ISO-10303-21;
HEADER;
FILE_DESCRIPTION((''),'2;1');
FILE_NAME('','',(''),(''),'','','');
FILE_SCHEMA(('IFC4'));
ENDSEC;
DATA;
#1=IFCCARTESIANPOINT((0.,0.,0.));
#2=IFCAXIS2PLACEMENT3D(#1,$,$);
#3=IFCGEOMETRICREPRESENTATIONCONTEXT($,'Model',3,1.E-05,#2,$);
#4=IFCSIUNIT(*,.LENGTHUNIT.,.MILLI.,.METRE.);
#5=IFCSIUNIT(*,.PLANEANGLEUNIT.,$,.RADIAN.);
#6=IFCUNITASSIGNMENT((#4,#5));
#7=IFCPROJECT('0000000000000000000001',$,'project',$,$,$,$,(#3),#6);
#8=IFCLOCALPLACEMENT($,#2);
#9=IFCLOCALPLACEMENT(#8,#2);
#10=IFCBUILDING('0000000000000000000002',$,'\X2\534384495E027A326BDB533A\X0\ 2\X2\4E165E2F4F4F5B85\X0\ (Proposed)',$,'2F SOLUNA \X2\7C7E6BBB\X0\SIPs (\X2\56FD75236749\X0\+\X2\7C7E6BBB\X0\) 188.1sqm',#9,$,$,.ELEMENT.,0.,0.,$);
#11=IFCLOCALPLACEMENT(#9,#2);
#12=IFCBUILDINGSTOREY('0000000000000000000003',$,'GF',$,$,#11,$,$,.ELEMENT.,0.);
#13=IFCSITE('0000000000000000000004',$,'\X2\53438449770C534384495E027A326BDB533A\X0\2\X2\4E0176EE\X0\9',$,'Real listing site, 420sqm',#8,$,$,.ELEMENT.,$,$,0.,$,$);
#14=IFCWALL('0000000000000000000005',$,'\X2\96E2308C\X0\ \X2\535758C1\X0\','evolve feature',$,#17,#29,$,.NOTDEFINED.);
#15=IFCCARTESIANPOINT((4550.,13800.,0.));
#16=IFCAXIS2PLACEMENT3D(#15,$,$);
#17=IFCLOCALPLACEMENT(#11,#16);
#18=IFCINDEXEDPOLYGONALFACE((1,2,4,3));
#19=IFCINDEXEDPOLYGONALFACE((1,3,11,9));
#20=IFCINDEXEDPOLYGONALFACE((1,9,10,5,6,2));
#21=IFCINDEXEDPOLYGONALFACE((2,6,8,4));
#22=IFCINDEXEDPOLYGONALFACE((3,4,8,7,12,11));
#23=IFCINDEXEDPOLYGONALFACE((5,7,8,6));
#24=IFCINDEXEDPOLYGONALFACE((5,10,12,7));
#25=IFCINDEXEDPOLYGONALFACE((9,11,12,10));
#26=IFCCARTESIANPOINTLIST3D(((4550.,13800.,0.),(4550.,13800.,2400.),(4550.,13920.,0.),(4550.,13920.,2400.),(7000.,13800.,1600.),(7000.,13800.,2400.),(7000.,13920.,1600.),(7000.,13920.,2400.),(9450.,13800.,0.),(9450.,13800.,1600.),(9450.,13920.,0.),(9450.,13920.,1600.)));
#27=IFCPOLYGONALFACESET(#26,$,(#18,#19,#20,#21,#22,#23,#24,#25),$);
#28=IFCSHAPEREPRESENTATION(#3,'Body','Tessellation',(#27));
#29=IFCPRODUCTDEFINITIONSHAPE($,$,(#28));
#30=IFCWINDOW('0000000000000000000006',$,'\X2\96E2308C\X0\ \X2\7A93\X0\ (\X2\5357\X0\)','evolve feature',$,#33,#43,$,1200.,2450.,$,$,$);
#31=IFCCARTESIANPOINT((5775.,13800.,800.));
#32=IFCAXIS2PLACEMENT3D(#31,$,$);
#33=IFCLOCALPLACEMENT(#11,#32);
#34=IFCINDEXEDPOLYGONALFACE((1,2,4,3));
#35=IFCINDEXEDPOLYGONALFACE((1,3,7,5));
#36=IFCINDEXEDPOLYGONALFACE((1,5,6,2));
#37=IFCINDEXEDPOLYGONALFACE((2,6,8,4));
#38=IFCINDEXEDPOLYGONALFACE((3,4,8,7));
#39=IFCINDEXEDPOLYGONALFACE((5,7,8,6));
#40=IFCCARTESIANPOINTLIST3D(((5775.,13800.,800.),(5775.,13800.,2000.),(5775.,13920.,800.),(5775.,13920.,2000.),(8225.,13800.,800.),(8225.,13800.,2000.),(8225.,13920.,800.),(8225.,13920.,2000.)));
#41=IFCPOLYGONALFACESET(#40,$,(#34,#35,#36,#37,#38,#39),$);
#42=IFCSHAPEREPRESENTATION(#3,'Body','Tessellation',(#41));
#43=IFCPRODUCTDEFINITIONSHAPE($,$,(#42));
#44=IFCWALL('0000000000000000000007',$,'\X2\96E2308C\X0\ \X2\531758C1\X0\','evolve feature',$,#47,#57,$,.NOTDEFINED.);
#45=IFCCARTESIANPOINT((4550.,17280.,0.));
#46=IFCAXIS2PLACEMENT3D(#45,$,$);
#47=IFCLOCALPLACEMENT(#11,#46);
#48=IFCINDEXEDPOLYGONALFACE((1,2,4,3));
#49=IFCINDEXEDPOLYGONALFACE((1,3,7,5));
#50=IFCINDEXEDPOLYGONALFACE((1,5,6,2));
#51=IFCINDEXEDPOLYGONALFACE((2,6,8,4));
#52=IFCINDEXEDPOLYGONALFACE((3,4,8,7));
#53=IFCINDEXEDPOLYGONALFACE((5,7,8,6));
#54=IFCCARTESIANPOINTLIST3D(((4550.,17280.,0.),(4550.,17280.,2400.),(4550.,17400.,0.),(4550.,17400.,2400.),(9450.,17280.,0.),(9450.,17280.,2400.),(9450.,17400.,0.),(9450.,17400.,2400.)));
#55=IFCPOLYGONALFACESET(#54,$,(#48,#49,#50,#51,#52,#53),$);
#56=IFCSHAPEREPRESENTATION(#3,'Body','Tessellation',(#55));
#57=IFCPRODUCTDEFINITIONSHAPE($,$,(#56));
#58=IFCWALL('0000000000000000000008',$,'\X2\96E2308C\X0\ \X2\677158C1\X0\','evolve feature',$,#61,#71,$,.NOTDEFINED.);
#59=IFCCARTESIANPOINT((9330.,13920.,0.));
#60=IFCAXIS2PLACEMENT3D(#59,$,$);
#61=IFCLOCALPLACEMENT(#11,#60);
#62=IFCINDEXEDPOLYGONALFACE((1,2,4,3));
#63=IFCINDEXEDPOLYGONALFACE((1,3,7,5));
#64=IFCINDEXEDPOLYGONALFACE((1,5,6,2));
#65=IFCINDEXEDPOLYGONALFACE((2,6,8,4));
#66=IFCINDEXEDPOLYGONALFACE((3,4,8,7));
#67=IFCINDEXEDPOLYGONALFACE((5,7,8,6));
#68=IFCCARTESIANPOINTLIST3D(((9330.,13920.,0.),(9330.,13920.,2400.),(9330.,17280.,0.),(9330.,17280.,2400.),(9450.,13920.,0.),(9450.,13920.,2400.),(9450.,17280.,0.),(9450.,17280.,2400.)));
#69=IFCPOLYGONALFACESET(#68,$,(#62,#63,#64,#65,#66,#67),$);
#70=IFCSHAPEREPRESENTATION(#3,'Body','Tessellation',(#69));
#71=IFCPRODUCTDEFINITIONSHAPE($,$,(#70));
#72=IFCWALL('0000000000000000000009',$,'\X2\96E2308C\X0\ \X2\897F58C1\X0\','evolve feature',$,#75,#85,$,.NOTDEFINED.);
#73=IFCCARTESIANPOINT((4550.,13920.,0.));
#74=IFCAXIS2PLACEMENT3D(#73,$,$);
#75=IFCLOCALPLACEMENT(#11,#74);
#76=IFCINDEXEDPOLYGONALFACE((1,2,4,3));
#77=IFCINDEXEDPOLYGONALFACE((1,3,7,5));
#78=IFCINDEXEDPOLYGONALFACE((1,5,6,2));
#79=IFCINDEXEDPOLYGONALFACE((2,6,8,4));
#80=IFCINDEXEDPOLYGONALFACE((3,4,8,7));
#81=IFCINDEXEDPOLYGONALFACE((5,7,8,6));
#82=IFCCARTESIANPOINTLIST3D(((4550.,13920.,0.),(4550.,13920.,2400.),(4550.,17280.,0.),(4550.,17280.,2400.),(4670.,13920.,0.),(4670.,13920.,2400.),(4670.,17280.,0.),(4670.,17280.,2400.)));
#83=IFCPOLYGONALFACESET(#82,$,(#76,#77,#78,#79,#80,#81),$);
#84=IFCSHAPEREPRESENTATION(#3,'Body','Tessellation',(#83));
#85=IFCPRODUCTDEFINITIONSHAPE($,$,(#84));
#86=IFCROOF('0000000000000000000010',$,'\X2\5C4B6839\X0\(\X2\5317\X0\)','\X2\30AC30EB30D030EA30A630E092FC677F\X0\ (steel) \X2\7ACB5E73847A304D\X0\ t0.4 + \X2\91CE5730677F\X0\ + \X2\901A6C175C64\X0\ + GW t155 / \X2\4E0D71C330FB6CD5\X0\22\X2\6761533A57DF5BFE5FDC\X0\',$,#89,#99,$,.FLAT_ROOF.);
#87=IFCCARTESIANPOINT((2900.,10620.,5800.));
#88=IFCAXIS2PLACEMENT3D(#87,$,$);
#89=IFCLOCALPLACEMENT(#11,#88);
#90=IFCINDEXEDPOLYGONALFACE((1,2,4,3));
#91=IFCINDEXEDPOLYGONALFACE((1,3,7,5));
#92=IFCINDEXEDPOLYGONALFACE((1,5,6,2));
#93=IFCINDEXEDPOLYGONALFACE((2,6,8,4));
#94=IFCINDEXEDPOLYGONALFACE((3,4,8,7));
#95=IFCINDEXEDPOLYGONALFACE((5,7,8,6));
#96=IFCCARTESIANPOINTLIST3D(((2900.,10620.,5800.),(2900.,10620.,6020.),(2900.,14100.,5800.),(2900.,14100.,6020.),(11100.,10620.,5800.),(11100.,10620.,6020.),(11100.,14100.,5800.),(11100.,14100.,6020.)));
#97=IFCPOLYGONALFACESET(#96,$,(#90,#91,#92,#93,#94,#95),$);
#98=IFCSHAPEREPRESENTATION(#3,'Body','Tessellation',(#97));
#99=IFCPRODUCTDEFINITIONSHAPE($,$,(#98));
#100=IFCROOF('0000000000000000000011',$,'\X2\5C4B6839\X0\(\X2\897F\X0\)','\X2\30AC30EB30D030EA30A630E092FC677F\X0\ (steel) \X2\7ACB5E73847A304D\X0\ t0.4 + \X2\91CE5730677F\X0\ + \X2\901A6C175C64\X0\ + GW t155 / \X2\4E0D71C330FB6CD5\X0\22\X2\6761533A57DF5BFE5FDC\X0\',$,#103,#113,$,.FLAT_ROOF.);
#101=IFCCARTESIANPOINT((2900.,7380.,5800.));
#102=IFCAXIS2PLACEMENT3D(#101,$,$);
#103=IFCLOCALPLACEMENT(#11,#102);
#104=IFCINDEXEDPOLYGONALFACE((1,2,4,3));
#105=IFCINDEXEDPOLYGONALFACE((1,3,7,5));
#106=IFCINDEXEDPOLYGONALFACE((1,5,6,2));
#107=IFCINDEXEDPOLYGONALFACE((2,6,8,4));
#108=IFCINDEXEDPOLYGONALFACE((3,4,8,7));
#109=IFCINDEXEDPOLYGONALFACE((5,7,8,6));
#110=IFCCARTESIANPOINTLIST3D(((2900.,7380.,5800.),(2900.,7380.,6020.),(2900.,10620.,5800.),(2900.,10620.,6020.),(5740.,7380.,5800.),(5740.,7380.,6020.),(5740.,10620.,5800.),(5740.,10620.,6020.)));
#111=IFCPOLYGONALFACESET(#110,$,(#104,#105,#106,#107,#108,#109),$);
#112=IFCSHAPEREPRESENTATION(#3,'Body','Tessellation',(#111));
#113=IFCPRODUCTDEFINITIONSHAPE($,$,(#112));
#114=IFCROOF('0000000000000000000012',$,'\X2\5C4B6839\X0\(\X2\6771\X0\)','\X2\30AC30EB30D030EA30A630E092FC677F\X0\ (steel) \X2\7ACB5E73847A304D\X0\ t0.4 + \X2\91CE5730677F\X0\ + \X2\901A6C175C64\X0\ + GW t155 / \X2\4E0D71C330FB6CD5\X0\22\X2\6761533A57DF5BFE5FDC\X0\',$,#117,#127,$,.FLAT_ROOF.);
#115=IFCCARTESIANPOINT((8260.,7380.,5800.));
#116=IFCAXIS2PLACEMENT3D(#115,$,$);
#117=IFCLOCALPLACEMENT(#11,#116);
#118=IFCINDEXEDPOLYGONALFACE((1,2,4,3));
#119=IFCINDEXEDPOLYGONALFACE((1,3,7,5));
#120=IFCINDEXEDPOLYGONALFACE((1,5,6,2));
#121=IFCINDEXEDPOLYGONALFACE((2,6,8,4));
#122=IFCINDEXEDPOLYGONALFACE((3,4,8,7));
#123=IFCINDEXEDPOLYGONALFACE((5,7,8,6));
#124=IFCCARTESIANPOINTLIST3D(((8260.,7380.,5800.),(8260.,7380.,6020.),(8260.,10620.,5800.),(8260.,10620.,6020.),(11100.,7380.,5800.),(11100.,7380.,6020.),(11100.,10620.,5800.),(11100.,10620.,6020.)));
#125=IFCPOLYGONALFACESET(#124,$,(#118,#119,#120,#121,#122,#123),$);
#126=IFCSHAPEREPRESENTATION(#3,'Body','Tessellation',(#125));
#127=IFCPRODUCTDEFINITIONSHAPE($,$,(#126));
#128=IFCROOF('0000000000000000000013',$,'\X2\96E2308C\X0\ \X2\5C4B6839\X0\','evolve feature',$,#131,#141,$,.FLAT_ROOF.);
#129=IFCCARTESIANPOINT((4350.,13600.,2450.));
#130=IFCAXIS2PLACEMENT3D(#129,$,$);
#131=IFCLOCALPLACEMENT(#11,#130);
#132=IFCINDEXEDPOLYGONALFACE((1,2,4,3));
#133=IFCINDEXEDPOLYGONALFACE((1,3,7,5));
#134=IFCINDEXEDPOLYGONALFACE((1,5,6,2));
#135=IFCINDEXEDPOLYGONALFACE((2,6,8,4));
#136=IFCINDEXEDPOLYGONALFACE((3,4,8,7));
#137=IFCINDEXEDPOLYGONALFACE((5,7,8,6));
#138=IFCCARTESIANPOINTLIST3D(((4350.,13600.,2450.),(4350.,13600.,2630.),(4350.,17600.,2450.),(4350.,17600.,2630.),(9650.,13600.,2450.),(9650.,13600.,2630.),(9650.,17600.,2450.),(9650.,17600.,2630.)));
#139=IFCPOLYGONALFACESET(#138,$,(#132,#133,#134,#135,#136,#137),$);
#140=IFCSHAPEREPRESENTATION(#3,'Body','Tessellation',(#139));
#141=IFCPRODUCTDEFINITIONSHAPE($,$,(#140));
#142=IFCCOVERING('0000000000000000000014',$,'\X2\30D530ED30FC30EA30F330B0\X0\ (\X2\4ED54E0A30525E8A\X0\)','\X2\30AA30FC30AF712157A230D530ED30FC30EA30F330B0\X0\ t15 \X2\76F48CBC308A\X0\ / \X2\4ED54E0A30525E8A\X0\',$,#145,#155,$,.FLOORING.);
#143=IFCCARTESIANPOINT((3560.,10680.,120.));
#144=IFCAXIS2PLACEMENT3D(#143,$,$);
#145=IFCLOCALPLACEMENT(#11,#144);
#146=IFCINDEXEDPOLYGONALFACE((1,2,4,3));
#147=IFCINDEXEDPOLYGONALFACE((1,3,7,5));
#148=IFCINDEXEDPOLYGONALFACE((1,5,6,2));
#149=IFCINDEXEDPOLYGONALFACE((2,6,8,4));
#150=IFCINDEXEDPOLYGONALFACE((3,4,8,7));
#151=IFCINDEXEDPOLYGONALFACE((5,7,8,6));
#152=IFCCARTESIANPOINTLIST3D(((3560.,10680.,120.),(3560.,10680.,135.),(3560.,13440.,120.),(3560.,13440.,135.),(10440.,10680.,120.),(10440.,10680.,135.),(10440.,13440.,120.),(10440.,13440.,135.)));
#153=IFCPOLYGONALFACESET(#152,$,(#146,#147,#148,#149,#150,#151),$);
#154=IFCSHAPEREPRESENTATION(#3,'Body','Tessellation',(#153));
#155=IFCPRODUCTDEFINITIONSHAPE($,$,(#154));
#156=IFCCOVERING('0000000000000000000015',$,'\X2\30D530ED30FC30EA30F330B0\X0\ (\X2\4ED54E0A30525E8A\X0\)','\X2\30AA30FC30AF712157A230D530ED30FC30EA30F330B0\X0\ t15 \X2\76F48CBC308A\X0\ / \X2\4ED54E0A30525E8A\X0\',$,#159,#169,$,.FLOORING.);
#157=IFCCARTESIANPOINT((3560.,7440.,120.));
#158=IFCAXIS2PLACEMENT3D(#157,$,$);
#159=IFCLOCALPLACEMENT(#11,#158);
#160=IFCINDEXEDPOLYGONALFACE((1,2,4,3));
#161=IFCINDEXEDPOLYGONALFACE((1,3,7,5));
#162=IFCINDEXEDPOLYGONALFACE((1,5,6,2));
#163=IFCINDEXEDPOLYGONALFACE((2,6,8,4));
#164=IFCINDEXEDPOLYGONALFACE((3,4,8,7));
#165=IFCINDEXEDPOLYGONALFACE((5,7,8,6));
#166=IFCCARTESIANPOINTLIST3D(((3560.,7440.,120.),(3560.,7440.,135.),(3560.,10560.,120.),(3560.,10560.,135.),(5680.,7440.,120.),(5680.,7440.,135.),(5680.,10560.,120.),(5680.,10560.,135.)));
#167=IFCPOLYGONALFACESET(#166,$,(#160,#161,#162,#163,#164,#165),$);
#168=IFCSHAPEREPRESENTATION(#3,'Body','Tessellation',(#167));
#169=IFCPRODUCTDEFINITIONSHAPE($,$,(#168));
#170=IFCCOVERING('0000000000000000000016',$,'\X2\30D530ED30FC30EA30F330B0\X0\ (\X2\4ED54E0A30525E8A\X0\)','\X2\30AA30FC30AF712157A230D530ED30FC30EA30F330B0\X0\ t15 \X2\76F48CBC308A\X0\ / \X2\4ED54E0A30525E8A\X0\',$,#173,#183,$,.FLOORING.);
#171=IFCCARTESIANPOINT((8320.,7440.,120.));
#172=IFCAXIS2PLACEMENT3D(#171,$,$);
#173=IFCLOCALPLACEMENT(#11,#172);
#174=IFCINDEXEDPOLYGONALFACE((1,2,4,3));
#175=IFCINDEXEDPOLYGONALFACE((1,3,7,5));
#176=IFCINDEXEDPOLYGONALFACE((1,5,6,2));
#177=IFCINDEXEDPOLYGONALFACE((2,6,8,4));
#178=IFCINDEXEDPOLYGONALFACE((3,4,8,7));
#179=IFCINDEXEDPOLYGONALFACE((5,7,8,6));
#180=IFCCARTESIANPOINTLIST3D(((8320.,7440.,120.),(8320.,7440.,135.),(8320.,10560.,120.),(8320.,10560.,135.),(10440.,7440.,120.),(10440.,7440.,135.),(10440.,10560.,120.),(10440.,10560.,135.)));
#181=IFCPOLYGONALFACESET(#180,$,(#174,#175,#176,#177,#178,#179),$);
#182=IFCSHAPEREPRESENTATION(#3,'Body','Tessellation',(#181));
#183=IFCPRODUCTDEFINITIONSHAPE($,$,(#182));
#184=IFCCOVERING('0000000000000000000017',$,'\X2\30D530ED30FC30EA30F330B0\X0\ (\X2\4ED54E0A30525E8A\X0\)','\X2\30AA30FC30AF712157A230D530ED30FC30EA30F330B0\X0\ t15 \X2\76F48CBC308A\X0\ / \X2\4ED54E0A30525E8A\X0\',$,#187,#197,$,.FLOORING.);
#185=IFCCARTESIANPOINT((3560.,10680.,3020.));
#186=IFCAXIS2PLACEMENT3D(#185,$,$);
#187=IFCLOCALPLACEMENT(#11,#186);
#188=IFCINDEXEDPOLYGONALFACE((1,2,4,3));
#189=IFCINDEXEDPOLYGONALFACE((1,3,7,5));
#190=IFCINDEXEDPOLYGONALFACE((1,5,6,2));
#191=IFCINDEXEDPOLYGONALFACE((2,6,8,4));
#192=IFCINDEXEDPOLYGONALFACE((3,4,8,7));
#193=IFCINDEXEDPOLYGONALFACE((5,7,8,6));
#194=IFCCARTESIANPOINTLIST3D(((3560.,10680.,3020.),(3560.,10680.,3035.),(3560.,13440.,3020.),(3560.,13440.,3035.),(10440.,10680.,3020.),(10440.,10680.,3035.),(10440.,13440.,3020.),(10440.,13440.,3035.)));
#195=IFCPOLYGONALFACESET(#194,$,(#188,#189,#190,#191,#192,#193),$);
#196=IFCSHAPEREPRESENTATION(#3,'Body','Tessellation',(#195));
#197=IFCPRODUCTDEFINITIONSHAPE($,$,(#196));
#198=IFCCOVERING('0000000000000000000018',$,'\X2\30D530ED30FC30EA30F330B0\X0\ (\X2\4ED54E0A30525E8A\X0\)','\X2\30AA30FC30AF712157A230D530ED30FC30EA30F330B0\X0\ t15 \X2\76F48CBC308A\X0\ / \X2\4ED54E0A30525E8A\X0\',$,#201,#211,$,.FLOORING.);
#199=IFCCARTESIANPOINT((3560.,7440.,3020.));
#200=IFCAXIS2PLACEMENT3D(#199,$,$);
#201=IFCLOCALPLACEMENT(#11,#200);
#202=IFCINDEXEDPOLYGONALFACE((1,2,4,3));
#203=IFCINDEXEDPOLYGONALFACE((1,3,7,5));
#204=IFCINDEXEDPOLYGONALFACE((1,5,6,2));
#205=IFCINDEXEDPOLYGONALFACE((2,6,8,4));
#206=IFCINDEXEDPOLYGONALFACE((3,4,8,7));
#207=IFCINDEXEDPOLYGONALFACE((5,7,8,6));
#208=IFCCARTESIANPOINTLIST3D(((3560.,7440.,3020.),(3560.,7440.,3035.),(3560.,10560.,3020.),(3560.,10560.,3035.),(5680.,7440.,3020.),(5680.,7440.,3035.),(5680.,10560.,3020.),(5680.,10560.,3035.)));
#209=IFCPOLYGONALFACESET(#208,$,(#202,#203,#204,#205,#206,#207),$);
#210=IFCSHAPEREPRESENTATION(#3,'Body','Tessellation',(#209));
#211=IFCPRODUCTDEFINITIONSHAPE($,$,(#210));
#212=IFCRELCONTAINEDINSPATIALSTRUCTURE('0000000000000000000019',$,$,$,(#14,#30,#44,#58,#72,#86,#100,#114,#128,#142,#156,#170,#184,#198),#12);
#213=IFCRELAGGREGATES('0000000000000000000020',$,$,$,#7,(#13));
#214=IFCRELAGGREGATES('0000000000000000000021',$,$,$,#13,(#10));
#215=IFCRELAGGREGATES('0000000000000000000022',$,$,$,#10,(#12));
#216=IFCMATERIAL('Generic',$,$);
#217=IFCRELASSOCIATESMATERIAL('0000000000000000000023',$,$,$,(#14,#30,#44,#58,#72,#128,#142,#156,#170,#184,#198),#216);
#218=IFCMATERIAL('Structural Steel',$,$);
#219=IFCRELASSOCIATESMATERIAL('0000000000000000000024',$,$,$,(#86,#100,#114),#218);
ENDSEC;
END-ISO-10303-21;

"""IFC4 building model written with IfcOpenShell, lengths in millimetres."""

from ifc_helpers import new_model, si_unit, frame, frame_2d, origin, place, context, project, spatial, rectangle, extrude, material, element, fill, save


model = new_model("IFC4")

# Units and contexts
model_context = context("Model", 3, precision=1e-05, world=origin())
ifc_project = project(units=[si_unit("LENGTHUNIT", "METRE", prefix="MILLI"), si_unit("PLANEANGLEUNIT", "RADIAN")], contexts=[model_context])

# Site, building, storey
site_placement = place(None, origin())
site = spatial("IfcSite", under=ifc_project, at=site_placement, Name="千葉県千葉市稲毛区2丁目9", ObjectType="Real listing site, 420sqm", CompositionType="ELEMENT", RefElevation=0.0)
building_placement = place(site_placement, origin())
building = spatial("IfcBuilding", under=site, at=building_placement, Name="千葉市稲毛区 2世帯住宅 (Proposed)", ObjectType="2F SOLUNA 籾殻SIPs (国産杉+籾殻) 188.1sqm", CompositionType="ELEMENT", ElevationOfRefHeight=0.0, ElevationOfTerrain=0.0)
storey_placement = place(building_placement, origin())
storey = spatial("IfcBuildingStorey", under=building, at=storey_placement, Name="GF", CompositionType="ELEMENT", Elevation=0.0)

# Shared definitions
ifc_material_1 = material(Name="Generic")

# Wall, opening, window
wall_1_placement = place(storey_placement, frame((4550.0, 13800.0, 0.0)))
wall_1 = element("IfcWall", 1, at=wall_1_placement, inside=storey, material=ifc_material_1, Name="離れ 南壁", Description="evolve feature", PredefinedType="NOTDEFINED", context=model_context, shape_type="SweptSolid", body=[
    extrude(rectangle(XDim=4900.0, YDim=120.0, at=frame_2d((2450.0, 60.0))), frame((4550.0, 13800.0, 0.0)), (0.0, 0.0, 1.0), 2400.0),
])
opening_1_placement = place(storey_placement, frame((5775.0, 13800.0, 800.0)))
opening_1 = element("IfcOpeningElement", 2, at=opening_1_placement, cuts=wall_1, PredefinedType="NOTDEFINED", context=model_context, shape_type="SweptSolid", body=[
    extrude(rectangle(XDim=2450.0, YDim=120.0, at=frame_2d((1225.0, 60.0))), frame((5775.0, 13800.0, 800.0)), (0.0, 0.0, 1.0), 1200.0),
])
window_1_placement = place(storey_placement, frame((5775.0, 13800.0, 800.0)))
window_1 = element("IfcWindow", 3, at=window_1_placement, inside=storey, material=ifc_material_1, Name="離れ 窓 (南)", Description="evolve feature", OverallHeight=1200.0, OverallWidth=2450.0, context=model_context, shape_type="SweptSolid", body=[
    extrude(rectangle(XDim=2450.0, YDim=120.0, at=frame_2d((1225.0, 60.0))), frame((5775.0, 13800.0, 800.0)), (0.0, 0.0, 1.0), 1200.0),
])
fill(opening_1, window_1)

# Walls
wall_2_placement = place(storey_placement, frame((4550.0, 17280.0, 0.0)))
element("IfcWall", 4, at=wall_2_placement, inside=storey, material=ifc_material_1, Name="離れ 北壁", Description="evolve feature", PredefinedType="NOTDEFINED", context=model_context, shape_type="SweptSolid", body=[
    extrude(rectangle(XDim=4900.0, YDim=120.0, at=frame_2d((2450.0, 60.0))), frame((4550.0, 17280.0, 0.0)), (0.0, 0.0, 1.0), 2400.0),
])
wall_3_placement = place(storey_placement, frame((9330.0, 13920.0, 0.0)))
element("IfcWall", 5, at=wall_3_placement, inside=storey, material=ifc_material_1, Name="離れ 東壁", Description="evolve feature", PredefinedType="NOTDEFINED", context=model_context, shape_type="SweptSolid", body=[
    extrude(rectangle(XDim=120.0, YDim=3360.0, at=frame_2d((60.0, 1680.0))), frame((9330.0, 13920.0, 0.0)), (0.0, 0.0, 1.0), 2400.0),
])
wall_4_placement = place(storey_placement, frame((4550.0, 13920.0, 0.0)))
element("IfcWall", 6, at=wall_4_placement, inside=storey, material=ifc_material_1, Name="離れ 西壁", Description="evolve feature", PredefinedType="NOTDEFINED", context=model_context, shape_type="SweptSolid", body=[
    extrude(rectangle(XDim=120.0, YDim=3360.0, at=frame_2d((60.0, 1680.0))), frame((4550.0, 13920.0, 0.0)), (0.0, 0.0, 1.0), 2400.0),
])

# Roofs
ifc_material_2 = material(Name="Structural Steel")
for number, where, name in (
    (7, (2900.0, 10620.0, 5800.0), "屋根(北)"),
):
    element("IfcRoof", number, at=place(storey_placement, frame(where)), inside=storey, material=ifc_material_2, Name=name, Description="ガルバリウム鋼板 (steel) 立平葺き t0.4 + 野地板 + 通気層 + GW t155 / 不燃・法22条区域対応", PredefinedType="FLAT_ROOF", context=model_context, shape_type="SweptSolid", body=[
        extrude(rectangle(XDim=8200.0, YDim=3480.0, at=frame_2d((4100.0, 1740.0))), frame((2900.0, 10620.0, 5800.0)), (0.0, 0.0, 1.0), 220.0),
    ])
roof_1_placement = place(storey_placement, frame((2900.0, 7380.0, 5800.0)))
element("IfcRoof", 8, at=roof_1_placement, inside=storey, material=ifc_material_2, Name="屋根(西)", Description="ガルバリウム鋼板 (steel) 立平葺き t0.4 + 野地板 + 通気層 + GW t155 / 不燃・法22条区域対応", PredefinedType="FLAT_ROOF", context=model_context, shape_type="SweptSolid", body=[
    extrude(rectangle(XDim=2840.0, YDim=3240.0, at=frame_2d((1420.0, 1620.0))), frame((2900.0, 7380.0, 5800.0)), (0.0, 0.0, 1.0), 220.0),
])
roof_2_placement = place(storey_placement, frame((8260.0, 7380.0, 5800.0)))
element("IfcRoof", 9, at=roof_2_placement, inside=storey, material=ifc_material_2, Name="屋根(東)", Description="ガルバリウム鋼板 (steel) 立平葺き t0.4 + 野地板 + 通気層 + GW t155 / 不燃・法22条区域対応", PredefinedType="FLAT_ROOF", context=model_context, shape_type="SweptSolid", body=[
    extrude(rectangle(XDim=2840.0, YDim=3240.0, at=frame_2d((1420.0, 1620.0))), frame((8260.0, 7380.0, 5800.0)), (0.0, 0.0, 1.0), 220.0),
])
roof_3_placement = place(storey_placement, frame((4350.0, 13600.0, 2450.0)))
element("IfcRoof", 10, at=roof_3_placement, inside=storey, material=ifc_material_1, Name="離れ 屋根", Description="evolve feature", PredefinedType="FLAT_ROOF", context=model_context, shape_type="SweptSolid", body=[
    extrude(rectangle(XDim=5300.0, YDim=4000.0, at=frame_2d((2650.0, 2000.0))), frame((4350.0, 13600.0, 2450.0)), (0.0, 0.0, 1.0), 180.0),
])

# Coverings
covering_1_placement = place(storey_placement, frame((3560.0, 10680.0, 120.0)))
element("IfcCovering", 11, at=covering_1_placement, inside=storey, material=ifc_material_1, Name="フローリング (仕上げ床)", Description="オーク無垢フローリング t15 直貼り / 仕上げ床", PredefinedType="FLOORING", context=model_context, shape_type="SweptSolid", body=[
    extrude(rectangle(XDim=6880.0, YDim=2760.0, at=frame_2d((3440.0, 1380.0))), frame((3560.0, 10680.0, 120.0)), (0.0, 0.0, 1.0), 15.0),
])
covering_2_placement = place(storey_placement, frame((3560.0, 7440.0, 120.0)))
element("IfcCovering", 12, at=covering_2_placement, inside=storey, material=ifc_material_1, Name="フローリング (仕上げ床)", Description="オーク無垢フローリング t15 直貼り / 仕上げ床", PredefinedType="FLOORING", context=model_context, shape_type="SweptSolid", body=[
    extrude(rectangle(XDim=2120.0, YDim=3120.0, at=frame_2d((1060.0, 1560.0))), frame((3560.0, 7440.0, 120.0)), (0.0, 0.0, 1.0), 15.0),
])
covering_3_placement = place(storey_placement, frame((8320.0, 7440.0, 120.0)))
element("IfcCovering", 13, at=covering_3_placement, inside=storey, material=ifc_material_1, Name="フローリング (仕上げ床)", Description="オーク無垢フローリング t15 直貼り / 仕上げ床", PredefinedType="FLOORING", context=model_context, shape_type="SweptSolid", body=[
    extrude(rectangle(XDim=2120.0, YDim=3120.0, at=frame_2d((1060.0, 1560.0))), frame((8320.0, 7440.0, 120.0)), (0.0, 0.0, 1.0), 15.0),
])
covering_4_placement = place(storey_placement, frame((3560.0, 10680.0, 3020.0)))
element("IfcCovering", 14, at=covering_4_placement, inside=storey, material=ifc_material_1, Name="フローリング (仕上げ床)", Description="オーク無垢フローリング t15 直貼り / 仕上げ床", PredefinedType="FLOORING", context=model_context, shape_type="SweptSolid", body=[
    extrude(rectangle(XDim=6880.0, YDim=2760.0, at=frame_2d((3440.0, 1380.0))), frame((3560.0, 10680.0, 3020.0)), (0.0, 0.0, 1.0), 15.0),
])
covering_5_placement = place(storey_placement, frame((3560.0, 7440.0, 3020.0)))
element("IfcCovering", 15, at=covering_5_placement, inside=storey, material=ifc_material_1, Name="フローリング (仕上げ床)", Description="オーク無垢フローリング t15 直貼り / 仕上げ床", PredefinedType="FLOORING", context=model_context, shape_type="SweptSolid", body=[
    extrude(rectangle(XDim=2120.0, YDim=3120.0, at=frame_2d((1060.0, 1560.0))), frame((3560.0, 7440.0, 3020.0)), (0.0, 0.0, 1.0), 15.0),
])

save(model, "model.ifc")
